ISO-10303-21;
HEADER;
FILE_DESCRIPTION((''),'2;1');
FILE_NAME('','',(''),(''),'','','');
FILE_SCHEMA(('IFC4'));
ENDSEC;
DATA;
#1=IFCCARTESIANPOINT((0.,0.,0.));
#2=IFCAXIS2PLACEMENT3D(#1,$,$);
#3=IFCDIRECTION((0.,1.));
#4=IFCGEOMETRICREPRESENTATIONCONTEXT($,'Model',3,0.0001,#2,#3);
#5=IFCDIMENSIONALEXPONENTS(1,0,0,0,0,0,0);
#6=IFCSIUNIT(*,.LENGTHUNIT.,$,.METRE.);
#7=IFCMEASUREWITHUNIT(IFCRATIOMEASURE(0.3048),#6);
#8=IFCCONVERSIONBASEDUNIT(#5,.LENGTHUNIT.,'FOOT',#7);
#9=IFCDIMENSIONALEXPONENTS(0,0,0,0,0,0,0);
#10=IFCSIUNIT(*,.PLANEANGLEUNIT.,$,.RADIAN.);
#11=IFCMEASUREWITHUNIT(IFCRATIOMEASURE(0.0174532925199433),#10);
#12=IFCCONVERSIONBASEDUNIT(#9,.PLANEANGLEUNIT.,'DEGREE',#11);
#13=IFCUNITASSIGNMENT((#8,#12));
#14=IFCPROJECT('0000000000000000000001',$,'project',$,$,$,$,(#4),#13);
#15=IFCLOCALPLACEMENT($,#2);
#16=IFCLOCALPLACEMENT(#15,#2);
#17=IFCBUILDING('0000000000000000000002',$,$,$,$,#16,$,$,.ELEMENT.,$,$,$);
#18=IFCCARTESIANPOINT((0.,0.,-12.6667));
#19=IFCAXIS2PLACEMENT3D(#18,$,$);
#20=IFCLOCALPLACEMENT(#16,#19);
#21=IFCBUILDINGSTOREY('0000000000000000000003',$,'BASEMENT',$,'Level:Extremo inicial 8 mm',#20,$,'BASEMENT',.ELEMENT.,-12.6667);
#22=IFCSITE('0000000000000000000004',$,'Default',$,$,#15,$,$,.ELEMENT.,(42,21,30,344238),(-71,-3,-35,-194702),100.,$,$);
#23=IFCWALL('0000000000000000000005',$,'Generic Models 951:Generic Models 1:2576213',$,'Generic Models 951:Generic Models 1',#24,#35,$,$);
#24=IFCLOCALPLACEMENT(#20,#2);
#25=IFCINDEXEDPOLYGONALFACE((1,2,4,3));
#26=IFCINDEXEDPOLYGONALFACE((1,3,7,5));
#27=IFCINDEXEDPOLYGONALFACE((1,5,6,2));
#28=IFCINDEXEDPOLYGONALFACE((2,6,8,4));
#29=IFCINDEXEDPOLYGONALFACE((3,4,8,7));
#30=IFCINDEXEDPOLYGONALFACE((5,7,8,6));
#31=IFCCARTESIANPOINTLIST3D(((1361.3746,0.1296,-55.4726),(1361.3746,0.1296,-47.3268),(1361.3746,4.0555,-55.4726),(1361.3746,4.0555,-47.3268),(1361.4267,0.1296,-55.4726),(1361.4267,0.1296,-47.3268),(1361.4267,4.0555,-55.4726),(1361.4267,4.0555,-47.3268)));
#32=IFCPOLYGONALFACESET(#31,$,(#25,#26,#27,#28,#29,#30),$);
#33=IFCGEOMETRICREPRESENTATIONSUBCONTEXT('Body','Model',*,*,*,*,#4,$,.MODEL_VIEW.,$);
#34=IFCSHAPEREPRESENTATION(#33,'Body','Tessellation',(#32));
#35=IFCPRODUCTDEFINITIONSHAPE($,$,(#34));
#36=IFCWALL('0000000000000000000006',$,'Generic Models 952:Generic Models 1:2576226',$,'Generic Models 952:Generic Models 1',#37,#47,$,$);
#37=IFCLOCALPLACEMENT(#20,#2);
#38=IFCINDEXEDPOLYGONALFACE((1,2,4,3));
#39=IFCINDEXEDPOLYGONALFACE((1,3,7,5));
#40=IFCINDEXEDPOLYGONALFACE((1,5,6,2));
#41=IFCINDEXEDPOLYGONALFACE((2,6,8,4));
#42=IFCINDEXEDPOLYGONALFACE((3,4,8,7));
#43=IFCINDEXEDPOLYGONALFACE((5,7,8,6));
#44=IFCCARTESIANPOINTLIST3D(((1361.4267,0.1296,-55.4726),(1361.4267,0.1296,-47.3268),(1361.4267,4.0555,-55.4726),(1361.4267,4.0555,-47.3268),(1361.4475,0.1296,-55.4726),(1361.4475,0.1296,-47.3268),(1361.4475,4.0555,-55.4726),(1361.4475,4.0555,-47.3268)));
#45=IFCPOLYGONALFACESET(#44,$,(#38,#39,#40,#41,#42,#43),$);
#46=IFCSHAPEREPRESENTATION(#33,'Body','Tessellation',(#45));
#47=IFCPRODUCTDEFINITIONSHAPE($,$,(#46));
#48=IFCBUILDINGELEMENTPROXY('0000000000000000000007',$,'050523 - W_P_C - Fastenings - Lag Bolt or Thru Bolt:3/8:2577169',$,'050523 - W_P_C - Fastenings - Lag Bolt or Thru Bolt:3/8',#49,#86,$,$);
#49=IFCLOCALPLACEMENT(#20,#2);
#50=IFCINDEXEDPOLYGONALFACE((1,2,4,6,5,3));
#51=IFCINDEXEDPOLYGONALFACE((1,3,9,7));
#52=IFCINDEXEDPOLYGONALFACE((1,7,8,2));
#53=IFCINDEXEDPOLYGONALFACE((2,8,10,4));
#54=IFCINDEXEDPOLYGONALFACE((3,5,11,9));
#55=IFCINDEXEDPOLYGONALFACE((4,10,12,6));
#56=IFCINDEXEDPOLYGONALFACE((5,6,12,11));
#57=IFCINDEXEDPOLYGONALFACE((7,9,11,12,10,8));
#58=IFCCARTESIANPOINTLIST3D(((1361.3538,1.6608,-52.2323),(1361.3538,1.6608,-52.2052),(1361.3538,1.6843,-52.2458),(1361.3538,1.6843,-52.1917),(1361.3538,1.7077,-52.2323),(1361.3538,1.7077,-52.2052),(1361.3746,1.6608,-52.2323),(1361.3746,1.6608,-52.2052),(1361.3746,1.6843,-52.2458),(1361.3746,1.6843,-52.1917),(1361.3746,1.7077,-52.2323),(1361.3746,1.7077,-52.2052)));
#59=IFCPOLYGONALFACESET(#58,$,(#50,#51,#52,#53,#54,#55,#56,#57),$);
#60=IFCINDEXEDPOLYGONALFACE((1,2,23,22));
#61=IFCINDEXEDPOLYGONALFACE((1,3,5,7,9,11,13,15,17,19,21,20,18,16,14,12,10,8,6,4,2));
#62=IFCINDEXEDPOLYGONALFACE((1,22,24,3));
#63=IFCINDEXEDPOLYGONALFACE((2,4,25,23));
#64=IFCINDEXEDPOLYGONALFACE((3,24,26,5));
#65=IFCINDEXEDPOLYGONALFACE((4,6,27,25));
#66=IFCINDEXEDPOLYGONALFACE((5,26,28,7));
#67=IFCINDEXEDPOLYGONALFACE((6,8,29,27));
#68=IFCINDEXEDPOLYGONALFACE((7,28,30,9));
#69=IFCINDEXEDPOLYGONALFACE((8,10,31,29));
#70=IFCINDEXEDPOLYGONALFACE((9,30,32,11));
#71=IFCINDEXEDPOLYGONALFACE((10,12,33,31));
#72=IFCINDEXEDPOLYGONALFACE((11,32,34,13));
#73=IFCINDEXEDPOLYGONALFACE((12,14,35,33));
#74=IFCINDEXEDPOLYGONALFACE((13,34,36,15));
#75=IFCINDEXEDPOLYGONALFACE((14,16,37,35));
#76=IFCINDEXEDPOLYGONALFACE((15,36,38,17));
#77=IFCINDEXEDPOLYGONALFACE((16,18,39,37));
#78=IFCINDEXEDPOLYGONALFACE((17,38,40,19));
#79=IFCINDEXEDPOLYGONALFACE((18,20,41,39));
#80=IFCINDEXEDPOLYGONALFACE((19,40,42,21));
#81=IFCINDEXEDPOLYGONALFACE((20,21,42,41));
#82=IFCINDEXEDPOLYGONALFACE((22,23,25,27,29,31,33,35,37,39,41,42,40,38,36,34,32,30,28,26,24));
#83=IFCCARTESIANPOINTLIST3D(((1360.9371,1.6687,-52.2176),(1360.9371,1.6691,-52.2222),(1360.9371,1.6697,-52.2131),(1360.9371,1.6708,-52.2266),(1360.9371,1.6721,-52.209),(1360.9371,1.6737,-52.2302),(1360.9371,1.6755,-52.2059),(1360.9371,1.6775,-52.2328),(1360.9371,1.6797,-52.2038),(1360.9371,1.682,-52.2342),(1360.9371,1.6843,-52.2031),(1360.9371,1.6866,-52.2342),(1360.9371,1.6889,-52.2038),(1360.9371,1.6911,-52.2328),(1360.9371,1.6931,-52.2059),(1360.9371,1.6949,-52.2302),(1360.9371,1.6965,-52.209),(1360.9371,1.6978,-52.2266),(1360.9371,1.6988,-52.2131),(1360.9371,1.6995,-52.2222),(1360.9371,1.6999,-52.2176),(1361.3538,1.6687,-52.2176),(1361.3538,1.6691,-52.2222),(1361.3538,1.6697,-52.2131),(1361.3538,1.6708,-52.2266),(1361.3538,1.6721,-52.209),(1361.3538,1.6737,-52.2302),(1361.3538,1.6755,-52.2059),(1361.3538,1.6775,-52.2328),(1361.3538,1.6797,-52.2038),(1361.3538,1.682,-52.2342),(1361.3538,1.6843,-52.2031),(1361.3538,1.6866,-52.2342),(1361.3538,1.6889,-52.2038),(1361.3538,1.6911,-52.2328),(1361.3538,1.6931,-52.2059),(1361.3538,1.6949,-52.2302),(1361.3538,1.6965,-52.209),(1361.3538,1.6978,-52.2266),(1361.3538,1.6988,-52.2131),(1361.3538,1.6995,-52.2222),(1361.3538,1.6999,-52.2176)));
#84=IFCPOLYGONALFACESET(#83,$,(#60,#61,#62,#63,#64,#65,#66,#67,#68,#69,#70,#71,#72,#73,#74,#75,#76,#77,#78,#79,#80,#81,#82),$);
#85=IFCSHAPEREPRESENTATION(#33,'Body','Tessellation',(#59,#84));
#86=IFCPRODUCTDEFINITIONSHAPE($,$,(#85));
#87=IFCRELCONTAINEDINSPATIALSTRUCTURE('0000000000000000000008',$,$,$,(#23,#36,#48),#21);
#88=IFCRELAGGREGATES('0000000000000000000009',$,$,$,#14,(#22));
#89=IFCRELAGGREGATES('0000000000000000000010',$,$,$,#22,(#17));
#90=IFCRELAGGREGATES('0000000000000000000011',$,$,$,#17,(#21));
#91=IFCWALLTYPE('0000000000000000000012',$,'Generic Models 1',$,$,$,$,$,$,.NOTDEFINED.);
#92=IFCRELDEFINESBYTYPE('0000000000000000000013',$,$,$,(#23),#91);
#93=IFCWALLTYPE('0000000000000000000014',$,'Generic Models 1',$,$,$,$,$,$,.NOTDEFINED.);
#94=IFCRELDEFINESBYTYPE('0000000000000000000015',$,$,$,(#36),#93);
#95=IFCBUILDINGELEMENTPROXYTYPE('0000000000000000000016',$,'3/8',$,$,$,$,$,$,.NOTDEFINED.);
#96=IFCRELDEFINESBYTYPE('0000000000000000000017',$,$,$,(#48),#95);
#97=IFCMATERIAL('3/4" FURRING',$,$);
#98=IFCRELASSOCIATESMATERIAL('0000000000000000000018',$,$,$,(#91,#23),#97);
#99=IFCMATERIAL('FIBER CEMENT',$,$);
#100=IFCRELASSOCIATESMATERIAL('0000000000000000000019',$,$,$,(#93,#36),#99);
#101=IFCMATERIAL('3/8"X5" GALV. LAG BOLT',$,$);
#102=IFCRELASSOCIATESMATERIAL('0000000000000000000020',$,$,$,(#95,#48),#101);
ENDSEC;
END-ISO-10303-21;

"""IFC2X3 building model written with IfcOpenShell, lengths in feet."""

from ifc_helpers import new_model, entity, si_unit, converted_unit, direction, frame, frame_2d, origin, place, context, subcontext, project, spatial, polyline, rectangle, circle, outline, extrude, source, transform, mapped, material, type_object, type_shapes, element, save


model = new_model("IFC2X3")

# Units and contexts
model_context = context("Model", 3, precision=0.0001, world=origin(), true_north=direction((0.0, 1.0)))
body_context = subcontext(model_context, "Body", "Model", "MODEL_VIEW")
ifc_project = project(units=[converted_unit("LENGTHUNIT", "FOOT", entity("IfcRatioMeasure", 0.3048), si_unit("LENGTHUNIT", "METRE"), dimensions=[1, 0, 0, 0, 0, 0, 0]), converted_unit("PLANEANGLEUNIT", "DEGREE", entity("IfcRatioMeasure", 0.0174532925199433), si_unit("PLANEANGLEUNIT", "RADIAN"), dimensions=[0, 0, 0, 0, 0, 0, 0])], contexts=[model_context])

# Site, building, storey
site_placement = place(None, origin())
site = spatial("IfcSite", under=ifc_project, at=site_placement, Name="Default", CompositionType="ELEMENT", RefLatitude=(42, 21, 30, 344238), RefLongitude=(-71, -3, -35, -194702), RefElevation=100.0)
building_placement = place(site_placement, origin())
building = spatial("IfcBuilding", under=site, at=building_placement, CompositionType="ELEMENT")
storey_placement = place(building_placement, frame((0.0, 0.0, -12.6667)))
storey = spatial("IfcBuildingStorey", under=building, at=storey_placement, Name="BASEMENT", ObjectType="Level:Extremo inicial 8 mm", LongName="BASEMENT", CompositionType="ELEMENT", Elevation=-12.6667)

# Walls
ifc_material_1 = material(Name="3/4\" FURRING")
wall_type_1 = type_object("IfcWallType", Name="Generic Models 1", PredefinedType="NOTDEFINED", material=ifc_material_1)
wall_1_placement = place(storey_placement, frame((1361.3746, 0.1296, -55.4726), z_axis=(0.0, 0.0, 1.0), x_axis=(0.0, 1.0, 0.0)))
element("IfcWall", 1, at=wall_1_placement, inside=storey, type_object=wall_type_1, material=ifc_material_1, Name="Generic Models 951:Generic Models 1:2576213", ObjectType="Generic Models 951:Generic Models 1", context=body_context, shape_type="SweptSolid", body=[
    extrude(rectangle(XDim=3.9258, YDim=0.0521, at=frame_2d((0.0, 0.0), x_axis=(1.0, 0.0))), frame((1.9629, -0.026, 0.0)), (0.0, 0.0, 1.0), 8.1457),
])
ifc_material_2 = material(Name="FIBER CEMENT")
wall_type_2 = type_object("IfcWallType", Name="Generic Models 1", PredefinedType="NOTDEFINED", material=ifc_material_2)
wall_2_placement = place(storey_placement, frame((1361.4267, 0.1296, -55.4726), z_axis=(0.0, 0.0, 1.0), x_axis=(0.0, 1.0, 0.0)))
element("IfcWall", 2, at=wall_2_placement, inside=storey, type_object=wall_type_2, material=ifc_material_2, Name="Generic Models 952:Generic Models 1:2576226", ObjectType="Generic Models 952:Generic Models 1", context=body_context, shape_type="SweptSolid", body=[
    extrude(rectangle(XDim=3.9258, YDim=0.0208, at=frame_2d((0.0, 0.0), x_axis=(1.0, 0.0))), frame((1.9629, -0.0104, 0.0)), (0.0, 0.0, 1.0), 8.1457),
])

# Building element proxy
ifc_material_3 = material(Name="3/8\"X5\" GALV. LAG BOLT")
building_element_proxy_type = type_object("IfcBuildingElementProxyType", Name="3/8", PredefinedType="NOTDEFINED", material=ifc_material_3)
shared_shape = source(origin(), body_context, "Body", "SweptSolid", [
    extrude(outline(polyline([(-0.0135, -0.0234), (0.0135, -0.0234), (0.0271, 0.0), (0.0135, 0.0234), (-0.0135, 0.0234), (-0.0271, 0.0), (-0.0135, -0.0234)])), frame((0.0, 0.0, 0.0), z_axis=(0.0, 0.0, 1.0), x_axis=(0.0, -1.0, 0.0)), (0.0, 0.0, 1.0), 0.0208),
    extrude(circle(Radius=0.0156, at=frame_2d((0.0, 0.0), x_axis=(1.0, 0.0))), frame((0.0, 0.0, -0.4167), z_axis=(0.0, 0.0, 1.0), x_axis=(0.0, 1.0, 0.0)), (0.0, 0.0, 1.0), 0.4167),
])
type_shapes(building_element_proxy_type, [shared_shape])
proxy_placement = place(storey_placement, frame((1361.3538, 1.6843, -52.2188), z_axis=(1.0, 0.0, 0.0), x_axis=(0.0, 1.0, 0.0)))
element("IfcBuildingElementProxy", 3, at=proxy_placement, inside=storey, type_object=building_element_proxy_type, material=ifc_material_3, Name="050523 - W_P_C - Fastenings - Lag Bolt or Thru Bolt:3/8:2577169", ObjectType="050523 - W_P_C - Fastenings - Lag Bolt or Thru Bolt:3/8", context=body_context, shape_type="MappedRepresentation", body=[
    mapped(shared_shape, transform((0.0, 0.0, 0.0), scale=1.0)),
])

save(model, "model.ifc")
